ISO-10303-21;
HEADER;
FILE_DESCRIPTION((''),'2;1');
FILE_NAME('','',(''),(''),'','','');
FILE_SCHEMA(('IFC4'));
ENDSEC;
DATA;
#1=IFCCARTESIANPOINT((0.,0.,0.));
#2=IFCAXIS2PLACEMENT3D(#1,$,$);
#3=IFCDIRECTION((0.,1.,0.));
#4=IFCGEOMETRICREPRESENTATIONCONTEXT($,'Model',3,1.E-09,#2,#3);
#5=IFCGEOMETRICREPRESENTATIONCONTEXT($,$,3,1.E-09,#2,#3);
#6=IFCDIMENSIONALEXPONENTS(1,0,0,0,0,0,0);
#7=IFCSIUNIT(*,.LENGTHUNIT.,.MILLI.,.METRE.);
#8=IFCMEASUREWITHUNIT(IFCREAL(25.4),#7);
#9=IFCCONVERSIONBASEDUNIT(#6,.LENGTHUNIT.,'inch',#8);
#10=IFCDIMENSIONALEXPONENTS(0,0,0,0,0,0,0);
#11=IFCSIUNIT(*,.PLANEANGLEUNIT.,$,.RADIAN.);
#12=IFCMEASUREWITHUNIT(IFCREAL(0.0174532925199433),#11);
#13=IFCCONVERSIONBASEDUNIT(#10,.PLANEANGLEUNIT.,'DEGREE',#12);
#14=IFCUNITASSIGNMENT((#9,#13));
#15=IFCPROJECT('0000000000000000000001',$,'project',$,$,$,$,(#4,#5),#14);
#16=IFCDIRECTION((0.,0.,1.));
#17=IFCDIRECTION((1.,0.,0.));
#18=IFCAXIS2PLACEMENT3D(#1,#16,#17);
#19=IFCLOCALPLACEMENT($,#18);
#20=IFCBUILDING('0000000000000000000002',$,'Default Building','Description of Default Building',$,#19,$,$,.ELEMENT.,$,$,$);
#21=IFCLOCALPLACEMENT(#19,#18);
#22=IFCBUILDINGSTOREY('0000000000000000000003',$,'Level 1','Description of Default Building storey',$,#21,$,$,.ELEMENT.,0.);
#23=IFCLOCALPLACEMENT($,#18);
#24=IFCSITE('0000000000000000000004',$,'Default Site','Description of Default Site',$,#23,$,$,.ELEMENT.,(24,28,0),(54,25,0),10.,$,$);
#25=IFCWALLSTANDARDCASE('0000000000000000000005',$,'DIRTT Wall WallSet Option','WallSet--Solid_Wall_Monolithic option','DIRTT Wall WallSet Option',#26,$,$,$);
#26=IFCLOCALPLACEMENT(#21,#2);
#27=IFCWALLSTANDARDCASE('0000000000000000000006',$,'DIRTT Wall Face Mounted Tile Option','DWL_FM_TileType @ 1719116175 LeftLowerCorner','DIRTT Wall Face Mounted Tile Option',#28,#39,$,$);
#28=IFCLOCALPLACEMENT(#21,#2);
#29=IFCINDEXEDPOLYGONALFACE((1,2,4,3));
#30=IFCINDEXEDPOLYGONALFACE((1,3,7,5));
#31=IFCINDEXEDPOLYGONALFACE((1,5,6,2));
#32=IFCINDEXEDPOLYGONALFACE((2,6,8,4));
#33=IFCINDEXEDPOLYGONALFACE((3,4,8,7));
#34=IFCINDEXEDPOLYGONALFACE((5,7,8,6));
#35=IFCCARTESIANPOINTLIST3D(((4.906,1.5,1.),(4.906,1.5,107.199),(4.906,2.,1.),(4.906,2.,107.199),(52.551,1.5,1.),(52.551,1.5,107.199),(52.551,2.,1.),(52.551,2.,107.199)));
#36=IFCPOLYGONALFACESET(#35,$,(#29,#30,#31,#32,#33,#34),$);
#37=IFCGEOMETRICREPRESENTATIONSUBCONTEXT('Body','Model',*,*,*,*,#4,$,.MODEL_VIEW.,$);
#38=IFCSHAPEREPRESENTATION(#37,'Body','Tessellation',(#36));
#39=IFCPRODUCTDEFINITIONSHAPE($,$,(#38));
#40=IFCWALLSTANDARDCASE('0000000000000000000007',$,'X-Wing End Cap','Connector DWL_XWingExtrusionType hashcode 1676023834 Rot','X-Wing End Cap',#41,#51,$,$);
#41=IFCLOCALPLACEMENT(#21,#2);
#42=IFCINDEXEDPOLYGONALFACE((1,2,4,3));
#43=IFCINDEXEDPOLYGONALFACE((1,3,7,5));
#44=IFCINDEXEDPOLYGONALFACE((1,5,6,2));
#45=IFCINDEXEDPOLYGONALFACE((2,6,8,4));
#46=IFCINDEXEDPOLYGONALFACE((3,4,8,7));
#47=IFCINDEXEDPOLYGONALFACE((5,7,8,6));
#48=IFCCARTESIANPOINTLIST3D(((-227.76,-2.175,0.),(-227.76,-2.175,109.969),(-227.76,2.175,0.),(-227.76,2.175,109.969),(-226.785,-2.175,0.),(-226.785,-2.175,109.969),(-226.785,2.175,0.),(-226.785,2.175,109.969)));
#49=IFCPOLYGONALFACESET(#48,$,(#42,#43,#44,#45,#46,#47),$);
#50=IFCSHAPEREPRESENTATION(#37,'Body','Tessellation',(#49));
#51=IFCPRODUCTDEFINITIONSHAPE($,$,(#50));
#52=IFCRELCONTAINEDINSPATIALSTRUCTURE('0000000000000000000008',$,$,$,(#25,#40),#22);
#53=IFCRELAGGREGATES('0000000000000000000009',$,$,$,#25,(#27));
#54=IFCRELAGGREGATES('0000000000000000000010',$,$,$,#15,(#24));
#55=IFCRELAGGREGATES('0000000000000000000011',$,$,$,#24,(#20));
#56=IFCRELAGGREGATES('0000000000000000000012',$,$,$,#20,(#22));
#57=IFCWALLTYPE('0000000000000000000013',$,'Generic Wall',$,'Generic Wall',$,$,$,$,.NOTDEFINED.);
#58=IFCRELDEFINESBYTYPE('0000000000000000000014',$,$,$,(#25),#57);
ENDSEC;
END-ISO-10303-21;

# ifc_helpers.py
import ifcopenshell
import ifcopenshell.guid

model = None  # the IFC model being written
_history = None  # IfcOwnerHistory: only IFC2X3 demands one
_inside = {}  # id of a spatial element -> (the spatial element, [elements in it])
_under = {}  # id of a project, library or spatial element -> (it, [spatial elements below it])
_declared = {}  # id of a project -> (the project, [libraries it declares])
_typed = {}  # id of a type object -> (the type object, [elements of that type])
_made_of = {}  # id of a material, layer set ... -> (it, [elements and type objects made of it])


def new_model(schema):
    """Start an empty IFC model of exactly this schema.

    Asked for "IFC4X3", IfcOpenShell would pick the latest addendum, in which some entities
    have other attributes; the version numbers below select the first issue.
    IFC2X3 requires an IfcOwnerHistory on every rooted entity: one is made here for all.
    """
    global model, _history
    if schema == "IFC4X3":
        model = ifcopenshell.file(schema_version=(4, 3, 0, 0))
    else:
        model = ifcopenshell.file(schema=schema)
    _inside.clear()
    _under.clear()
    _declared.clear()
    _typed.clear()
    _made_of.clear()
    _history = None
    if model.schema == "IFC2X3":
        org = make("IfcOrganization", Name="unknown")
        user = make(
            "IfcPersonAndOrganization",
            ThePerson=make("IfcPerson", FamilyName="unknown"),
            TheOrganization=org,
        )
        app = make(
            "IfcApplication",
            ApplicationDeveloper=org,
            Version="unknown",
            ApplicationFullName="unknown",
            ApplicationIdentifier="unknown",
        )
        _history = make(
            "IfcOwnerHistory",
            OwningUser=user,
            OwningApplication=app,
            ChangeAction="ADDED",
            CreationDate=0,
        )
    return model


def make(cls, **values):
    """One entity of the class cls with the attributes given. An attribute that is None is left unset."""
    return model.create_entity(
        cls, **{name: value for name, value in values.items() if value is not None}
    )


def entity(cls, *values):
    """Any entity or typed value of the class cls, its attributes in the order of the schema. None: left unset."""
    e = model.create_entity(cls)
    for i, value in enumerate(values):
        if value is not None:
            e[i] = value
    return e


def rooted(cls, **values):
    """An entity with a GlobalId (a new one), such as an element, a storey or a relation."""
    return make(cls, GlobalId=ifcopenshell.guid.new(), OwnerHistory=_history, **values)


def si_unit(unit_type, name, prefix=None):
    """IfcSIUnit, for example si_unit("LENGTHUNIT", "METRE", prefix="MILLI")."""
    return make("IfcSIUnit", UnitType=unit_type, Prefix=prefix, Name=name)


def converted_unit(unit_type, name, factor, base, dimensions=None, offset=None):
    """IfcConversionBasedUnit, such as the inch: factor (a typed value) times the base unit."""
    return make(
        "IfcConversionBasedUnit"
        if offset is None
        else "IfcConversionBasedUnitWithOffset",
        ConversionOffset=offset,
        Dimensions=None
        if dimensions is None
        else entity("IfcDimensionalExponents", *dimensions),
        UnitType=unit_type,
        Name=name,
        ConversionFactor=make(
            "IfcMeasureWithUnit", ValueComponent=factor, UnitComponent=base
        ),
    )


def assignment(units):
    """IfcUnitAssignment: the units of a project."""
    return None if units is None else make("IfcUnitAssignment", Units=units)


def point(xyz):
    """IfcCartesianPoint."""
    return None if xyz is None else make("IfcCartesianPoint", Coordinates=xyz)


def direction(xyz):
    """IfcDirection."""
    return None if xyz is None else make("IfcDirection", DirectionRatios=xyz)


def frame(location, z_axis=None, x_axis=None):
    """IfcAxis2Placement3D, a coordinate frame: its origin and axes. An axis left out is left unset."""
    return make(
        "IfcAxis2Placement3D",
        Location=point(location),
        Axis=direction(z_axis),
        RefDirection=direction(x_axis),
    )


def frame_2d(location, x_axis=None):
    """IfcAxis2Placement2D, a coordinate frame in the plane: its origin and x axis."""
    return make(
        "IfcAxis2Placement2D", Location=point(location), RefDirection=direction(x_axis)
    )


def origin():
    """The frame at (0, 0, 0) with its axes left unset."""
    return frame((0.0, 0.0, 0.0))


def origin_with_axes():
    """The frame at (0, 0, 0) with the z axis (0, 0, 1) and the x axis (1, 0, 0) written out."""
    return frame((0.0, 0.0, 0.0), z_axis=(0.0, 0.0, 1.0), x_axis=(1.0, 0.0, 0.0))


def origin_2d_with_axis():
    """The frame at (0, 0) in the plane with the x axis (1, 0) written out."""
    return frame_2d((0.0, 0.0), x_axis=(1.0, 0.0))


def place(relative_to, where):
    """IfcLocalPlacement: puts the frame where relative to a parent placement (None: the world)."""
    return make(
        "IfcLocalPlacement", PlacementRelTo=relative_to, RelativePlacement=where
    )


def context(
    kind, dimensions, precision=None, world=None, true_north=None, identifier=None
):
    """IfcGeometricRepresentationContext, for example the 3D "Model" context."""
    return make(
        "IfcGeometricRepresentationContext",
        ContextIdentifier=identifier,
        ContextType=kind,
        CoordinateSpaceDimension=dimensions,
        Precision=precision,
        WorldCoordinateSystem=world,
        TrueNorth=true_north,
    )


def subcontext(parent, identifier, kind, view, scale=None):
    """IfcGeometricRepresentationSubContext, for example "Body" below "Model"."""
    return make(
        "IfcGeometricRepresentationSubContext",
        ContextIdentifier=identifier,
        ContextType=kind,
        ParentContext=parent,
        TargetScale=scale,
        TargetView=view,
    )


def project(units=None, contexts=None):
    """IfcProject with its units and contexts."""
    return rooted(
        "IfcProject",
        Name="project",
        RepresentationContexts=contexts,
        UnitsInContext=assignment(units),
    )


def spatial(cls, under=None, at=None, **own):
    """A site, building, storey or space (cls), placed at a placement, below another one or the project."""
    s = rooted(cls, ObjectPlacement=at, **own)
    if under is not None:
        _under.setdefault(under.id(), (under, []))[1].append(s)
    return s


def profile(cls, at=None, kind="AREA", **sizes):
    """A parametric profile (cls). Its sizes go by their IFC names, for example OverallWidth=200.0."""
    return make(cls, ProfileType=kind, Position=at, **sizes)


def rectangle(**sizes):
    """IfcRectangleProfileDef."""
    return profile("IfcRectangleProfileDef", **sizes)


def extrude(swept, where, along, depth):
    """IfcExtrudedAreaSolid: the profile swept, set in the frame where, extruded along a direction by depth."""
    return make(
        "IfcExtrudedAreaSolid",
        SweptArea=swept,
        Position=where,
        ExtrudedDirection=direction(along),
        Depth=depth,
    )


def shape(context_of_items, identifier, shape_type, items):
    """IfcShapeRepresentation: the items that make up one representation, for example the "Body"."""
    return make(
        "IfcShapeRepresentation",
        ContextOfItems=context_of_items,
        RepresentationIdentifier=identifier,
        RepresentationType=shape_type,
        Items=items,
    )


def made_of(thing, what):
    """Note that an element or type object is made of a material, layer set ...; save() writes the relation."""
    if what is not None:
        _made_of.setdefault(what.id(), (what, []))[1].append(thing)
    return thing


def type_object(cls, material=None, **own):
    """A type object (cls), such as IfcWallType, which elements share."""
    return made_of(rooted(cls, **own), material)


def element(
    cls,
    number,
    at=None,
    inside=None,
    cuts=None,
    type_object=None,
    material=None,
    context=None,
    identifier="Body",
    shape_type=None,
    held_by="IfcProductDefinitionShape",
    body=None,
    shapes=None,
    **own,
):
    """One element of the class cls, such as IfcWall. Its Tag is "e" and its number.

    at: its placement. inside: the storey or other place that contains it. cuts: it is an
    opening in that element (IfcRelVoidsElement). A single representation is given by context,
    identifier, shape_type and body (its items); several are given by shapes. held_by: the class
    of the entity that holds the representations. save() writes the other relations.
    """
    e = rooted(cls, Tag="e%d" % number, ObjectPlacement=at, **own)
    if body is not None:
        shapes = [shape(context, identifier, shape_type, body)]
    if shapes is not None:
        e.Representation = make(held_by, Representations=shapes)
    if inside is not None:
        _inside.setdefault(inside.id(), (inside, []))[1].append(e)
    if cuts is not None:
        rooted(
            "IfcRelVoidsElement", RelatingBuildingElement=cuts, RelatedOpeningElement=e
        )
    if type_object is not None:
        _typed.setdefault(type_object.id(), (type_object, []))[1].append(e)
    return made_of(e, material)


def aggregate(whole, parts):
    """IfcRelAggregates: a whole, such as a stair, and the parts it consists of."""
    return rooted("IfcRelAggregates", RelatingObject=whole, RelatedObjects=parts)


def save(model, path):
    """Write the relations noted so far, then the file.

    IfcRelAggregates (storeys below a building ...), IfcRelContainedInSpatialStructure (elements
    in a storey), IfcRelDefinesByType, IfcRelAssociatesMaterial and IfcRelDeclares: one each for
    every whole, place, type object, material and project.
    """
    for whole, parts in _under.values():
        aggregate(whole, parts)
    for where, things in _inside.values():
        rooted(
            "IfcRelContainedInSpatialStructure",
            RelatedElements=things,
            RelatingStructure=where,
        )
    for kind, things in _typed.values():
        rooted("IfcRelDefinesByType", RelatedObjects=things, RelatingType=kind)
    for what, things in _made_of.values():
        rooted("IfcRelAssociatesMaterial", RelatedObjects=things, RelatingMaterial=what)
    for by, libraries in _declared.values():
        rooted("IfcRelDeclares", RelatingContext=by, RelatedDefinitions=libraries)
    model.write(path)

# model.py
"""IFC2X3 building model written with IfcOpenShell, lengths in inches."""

from ifc_helpers import new_model, entity, si_unit, converted_unit, direction, frame, origin, origin_with_axes, origin_2d_with_axis, place, context, subcontext, project, spatial, rectangle, extrude, type_object, element, aggregate, save


model = new_model("IFC2X3")

# Units and contexts
model_context = context("Model", 3, precision=1e-09, world=origin(), true_north=direction((0.0, 1.0, 0.0)))
context_of_model = context(None, 3, precision=1e-09, world=origin(), true_north=direction((0.0, 1.0, 0.0)))
body_context = subcontext(model_context, "Body", "Model", "MODEL_VIEW")
ifc_project = project(units=[converted_unit("LENGTHUNIT", "inch", entity("IfcReal", 25.4), si_unit("LENGTHUNIT", "METRE", prefix="MILLI"), dimensions=[1, 0, 0, 0, 0, 0, 0]), converted_unit("PLANEANGLEUNIT", "DEGREE", entity("IfcReal", 0.0174532925199433), si_unit("PLANEANGLEUNIT", "RADIAN"), dimensions=[0, 0, 0, 0, 0, 0, 0])], contexts=[model_context, context_of_model])

# Site, building, storey
site_placement = place(None, origin_with_axes())
site = spatial("IfcSite", under=ifc_project, at=site_placement, Name="Default Site", Description="Description of Default Site", CompositionType="ELEMENT", RefLatitude=(24, 28, 0), RefLongitude=(54, 25, 0), RefElevation=10.0)
building_placement = place(None, origin_with_axes())
building = spatial("IfcBuilding", under=site, at=building_placement, Name="Default Building", Description="Description of Default Building", CompositionType="ELEMENT")
storey_placement = place(building_placement, origin_with_axes())
storey = spatial("IfcBuildingStorey", under=building, at=storey_placement, Name="Level 1", Description="Description of Default Building storey", CompositionType="ELEMENT", Elevation=0.0)

# Wall
wall_type_1 = type_object("IfcWallType", Name="Generic Wall", ApplicableOccurrence="Generic Wall", PredefinedType="NOTDEFINED")
placement_1 = place(storey_placement, origin_with_axes())
wall_1 = element("IfcWallStandardCase", 1, at=placement_1, inside=storey, type_object=wall_type_1, Name="DIRTT Wall WallSet Option", Description="WallSet--Solid_Wall_Monolithic option", ObjectType="DIRTT Wall WallSet Option")

# Walls
wall_2_placement = place(placement_1, origin_with_axes())
wall_2 = element("IfcWallStandardCase", 2, at=wall_2_placement, Name="DIRTT Wall Face Mounted Tile Option", Description="DWL_FM_TileType @ 1719116175 LeftLowerCorner", ObjectType="DIRTT Wall Face Mounted Tile Option", context=body_context, shape_type="SweptSolid", body=[
    extrude(rectangle(XDim=47.646, YDim=0.5, at=origin_2d_with_axis()), frame((28.729, 1.75, 1.0), z_axis=(0.0, 0.0, 1.0), x_axis=(-1.0, 0.0, 0.0)), (0.0, 0.0, 1.0), 106.199),
])
aggregate(wall_1, [wall_2])
element("IfcWallStandardCase", 3, at=placement_1, inside=storey, Name="X-Wing End Cap", Description="Connector DWL_XWingExtrusionType hashcode 1676023834 Rot", ObjectType="X-Wing End Cap", context=body_context, shape_type="SweptSolid", body=[
    extrude(rectangle(XDim=4.35, YDim=0.975, at=origin_2d_with_axis()), frame((-227.273, 0.0, 0.0), z_axis=(0.0, 0.0, 1.0), x_axis=(0.0, 1.0, 0.0)), (0.0, 0.0, 1.0), 109.969),
])

save(model, "model.ifc")
